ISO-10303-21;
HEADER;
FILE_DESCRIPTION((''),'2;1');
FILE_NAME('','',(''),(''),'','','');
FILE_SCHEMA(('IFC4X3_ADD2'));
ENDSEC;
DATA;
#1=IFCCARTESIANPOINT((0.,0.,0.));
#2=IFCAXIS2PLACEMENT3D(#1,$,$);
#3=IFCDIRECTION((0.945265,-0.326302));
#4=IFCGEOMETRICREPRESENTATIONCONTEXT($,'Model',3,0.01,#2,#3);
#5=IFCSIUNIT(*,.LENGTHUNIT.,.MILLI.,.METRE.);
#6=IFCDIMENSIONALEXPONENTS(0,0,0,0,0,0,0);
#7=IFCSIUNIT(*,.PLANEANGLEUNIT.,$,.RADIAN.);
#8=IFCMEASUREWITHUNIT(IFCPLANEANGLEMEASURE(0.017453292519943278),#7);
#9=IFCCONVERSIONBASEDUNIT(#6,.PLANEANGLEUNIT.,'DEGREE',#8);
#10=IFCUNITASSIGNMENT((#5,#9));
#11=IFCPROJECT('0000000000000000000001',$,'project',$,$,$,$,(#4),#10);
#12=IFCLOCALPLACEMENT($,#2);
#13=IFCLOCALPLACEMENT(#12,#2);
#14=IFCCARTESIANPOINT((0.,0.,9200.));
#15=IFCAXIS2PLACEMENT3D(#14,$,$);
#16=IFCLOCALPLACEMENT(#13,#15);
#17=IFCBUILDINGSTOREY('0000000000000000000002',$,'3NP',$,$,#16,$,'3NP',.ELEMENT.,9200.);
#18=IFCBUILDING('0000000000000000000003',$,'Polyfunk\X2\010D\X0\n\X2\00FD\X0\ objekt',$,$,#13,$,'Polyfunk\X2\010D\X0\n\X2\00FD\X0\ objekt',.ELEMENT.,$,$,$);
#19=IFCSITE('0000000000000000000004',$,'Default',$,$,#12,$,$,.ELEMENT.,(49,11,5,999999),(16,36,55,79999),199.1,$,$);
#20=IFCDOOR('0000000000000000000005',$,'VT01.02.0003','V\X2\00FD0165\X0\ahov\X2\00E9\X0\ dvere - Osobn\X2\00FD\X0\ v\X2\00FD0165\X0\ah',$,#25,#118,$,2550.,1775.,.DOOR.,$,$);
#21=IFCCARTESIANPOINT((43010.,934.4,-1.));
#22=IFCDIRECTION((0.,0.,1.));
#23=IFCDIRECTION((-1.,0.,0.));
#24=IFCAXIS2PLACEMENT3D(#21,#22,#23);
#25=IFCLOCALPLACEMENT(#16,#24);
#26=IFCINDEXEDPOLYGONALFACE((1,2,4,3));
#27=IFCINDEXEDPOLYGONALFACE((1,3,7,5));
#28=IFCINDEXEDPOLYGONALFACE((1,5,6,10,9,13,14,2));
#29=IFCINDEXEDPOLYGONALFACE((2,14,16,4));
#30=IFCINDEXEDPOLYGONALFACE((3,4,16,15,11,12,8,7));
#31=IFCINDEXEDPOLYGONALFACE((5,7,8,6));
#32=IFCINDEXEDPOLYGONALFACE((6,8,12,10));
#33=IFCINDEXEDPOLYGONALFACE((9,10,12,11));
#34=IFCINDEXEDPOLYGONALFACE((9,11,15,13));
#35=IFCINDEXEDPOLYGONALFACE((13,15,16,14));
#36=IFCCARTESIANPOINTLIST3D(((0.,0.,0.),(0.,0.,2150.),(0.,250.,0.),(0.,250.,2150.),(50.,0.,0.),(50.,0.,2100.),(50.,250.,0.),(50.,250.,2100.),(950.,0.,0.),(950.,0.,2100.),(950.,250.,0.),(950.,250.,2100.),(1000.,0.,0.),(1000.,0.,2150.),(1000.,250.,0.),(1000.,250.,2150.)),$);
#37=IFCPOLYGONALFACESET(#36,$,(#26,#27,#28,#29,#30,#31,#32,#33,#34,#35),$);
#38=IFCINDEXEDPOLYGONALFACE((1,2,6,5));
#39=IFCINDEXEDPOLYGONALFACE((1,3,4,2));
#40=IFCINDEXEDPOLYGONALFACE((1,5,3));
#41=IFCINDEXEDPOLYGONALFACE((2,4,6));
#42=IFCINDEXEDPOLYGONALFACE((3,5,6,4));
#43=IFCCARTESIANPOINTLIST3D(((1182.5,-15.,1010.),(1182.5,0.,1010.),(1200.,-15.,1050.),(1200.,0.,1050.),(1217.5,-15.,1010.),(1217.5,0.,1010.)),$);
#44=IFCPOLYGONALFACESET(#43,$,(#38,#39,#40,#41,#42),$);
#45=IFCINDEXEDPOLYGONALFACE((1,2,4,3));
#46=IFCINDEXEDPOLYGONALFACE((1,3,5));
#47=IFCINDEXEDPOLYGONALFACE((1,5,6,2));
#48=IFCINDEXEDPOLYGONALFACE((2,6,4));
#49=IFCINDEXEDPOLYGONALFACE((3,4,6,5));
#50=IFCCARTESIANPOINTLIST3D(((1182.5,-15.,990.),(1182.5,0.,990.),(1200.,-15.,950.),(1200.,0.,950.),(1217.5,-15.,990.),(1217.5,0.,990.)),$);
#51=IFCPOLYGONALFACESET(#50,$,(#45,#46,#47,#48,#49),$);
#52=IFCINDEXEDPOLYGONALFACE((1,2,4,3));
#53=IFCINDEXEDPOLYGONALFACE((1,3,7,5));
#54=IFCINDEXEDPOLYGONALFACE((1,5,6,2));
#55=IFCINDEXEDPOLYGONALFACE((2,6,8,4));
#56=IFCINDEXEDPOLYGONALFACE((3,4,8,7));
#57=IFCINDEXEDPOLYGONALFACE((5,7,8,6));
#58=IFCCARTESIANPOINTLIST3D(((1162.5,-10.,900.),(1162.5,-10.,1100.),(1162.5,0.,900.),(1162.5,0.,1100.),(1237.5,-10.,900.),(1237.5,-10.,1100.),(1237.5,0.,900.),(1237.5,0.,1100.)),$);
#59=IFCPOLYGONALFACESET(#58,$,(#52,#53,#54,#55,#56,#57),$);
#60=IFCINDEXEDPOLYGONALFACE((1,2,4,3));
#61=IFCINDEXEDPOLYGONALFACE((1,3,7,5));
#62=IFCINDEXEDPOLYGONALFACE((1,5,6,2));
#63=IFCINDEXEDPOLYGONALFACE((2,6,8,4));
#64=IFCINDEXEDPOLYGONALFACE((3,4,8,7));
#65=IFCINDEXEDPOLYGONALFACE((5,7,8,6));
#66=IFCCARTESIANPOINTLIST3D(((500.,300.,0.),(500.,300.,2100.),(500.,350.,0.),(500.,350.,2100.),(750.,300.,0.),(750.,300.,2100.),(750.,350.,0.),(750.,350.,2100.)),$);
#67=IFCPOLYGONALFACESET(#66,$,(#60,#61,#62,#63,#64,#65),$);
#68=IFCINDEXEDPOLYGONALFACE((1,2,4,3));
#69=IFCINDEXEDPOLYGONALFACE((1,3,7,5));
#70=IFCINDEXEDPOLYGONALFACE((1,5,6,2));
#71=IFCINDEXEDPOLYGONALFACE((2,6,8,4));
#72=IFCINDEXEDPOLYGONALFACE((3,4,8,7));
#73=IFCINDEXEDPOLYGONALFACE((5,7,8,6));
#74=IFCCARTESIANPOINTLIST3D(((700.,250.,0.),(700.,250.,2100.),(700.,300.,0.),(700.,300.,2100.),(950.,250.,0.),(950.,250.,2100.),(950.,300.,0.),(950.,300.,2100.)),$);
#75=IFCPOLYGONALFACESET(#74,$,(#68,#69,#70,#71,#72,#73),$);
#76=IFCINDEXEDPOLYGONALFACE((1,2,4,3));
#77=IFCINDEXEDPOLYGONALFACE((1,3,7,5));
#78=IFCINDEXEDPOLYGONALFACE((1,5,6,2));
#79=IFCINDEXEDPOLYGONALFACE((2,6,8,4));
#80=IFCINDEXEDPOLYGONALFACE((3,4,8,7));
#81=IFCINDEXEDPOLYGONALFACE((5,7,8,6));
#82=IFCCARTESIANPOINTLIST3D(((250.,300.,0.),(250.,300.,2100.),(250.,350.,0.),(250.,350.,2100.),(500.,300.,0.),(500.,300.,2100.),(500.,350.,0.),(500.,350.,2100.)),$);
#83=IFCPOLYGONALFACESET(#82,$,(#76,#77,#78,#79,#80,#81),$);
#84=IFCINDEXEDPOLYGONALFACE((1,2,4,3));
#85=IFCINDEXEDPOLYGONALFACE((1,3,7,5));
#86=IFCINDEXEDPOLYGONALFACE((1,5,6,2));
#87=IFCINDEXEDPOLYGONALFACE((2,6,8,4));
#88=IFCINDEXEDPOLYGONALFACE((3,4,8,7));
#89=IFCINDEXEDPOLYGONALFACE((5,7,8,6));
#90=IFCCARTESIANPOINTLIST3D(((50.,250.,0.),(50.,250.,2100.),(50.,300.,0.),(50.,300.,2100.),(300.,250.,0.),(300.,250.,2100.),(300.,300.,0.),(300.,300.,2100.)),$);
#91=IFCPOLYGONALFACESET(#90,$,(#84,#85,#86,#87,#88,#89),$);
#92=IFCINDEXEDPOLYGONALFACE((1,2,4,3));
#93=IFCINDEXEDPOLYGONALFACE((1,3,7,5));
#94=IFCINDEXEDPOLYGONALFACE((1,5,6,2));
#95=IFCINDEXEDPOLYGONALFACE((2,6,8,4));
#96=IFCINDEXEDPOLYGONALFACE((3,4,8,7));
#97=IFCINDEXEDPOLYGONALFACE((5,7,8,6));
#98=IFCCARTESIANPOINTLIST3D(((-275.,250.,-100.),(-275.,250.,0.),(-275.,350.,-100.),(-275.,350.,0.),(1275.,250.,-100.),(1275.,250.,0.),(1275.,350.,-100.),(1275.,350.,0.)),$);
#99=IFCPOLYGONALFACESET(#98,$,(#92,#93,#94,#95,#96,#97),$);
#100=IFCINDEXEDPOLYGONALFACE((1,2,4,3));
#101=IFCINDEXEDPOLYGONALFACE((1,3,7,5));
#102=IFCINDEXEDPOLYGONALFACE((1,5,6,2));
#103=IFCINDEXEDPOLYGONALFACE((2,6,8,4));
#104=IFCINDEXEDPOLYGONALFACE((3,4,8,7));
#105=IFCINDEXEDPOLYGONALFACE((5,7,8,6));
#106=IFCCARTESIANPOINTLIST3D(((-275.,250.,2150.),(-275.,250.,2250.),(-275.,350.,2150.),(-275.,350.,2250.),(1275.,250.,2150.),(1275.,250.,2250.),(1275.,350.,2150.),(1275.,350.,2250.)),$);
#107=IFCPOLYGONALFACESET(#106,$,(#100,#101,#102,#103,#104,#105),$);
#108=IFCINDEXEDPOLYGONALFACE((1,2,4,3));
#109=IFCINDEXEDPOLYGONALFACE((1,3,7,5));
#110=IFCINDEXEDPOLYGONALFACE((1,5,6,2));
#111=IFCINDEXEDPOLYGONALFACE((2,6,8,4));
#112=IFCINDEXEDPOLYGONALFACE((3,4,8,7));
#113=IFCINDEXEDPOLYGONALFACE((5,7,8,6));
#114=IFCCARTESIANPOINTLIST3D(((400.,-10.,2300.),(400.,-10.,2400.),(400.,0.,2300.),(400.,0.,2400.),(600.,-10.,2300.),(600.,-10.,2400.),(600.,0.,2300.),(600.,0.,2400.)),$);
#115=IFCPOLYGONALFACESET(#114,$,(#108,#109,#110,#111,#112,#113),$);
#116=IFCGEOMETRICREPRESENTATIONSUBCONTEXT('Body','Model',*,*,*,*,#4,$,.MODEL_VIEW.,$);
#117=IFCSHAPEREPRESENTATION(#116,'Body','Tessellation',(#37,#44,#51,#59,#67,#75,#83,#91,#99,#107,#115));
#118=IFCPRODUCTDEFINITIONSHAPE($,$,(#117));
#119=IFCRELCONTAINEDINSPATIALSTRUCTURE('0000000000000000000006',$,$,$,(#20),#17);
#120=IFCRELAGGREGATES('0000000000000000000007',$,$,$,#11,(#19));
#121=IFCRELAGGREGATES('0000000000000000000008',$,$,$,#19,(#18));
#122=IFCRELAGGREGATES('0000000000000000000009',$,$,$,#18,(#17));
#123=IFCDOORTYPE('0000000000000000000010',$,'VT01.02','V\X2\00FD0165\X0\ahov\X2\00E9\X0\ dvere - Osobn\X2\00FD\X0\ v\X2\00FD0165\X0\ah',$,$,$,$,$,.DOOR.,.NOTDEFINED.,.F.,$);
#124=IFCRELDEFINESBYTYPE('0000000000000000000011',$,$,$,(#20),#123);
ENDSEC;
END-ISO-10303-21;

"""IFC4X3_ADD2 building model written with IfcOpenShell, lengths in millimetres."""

from ifc_helpers import new_model, entity, si_unit, converted_unit, direction, frame, frame_2d, origin, origin_2d_with_axis, place, context, subcontext, project, spatial, polyline, rectangle, outline, extrude, source, transform, mapped, type_object, type_shapes, element, save


model = new_model("IFC4X3_ADD2")

# Units and contexts
model_context = context("Model", 3, precision=0.01, world=origin(), true_north=direction((0.945265, -0.326302)))
body_context = subcontext(model_context, "Body", "Model", "MODEL_VIEW")
ifc_project = project(units=[si_unit("LENGTHUNIT", "METRE", prefix="MILLI"), converted_unit("PLANEANGLEUNIT", "DEGREE", entity("IfcPlaneAngleMeasure", 0.017453292519943278), si_unit("PLANEANGLEUNIT", "RADIAN"), dimensions=[0, 0, 0, 0, 0, 0, 0])], contexts=[model_context])

# Site, building, storey
site_placement = place(None, origin())
site = spatial("IfcSite", under=ifc_project, at=site_placement, Name="Default", CompositionType="ELEMENT", RefLatitude=(49, 11, 5, 999999), RefLongitude=(16, 36, 55, 79999), RefElevation=199.1)
building_placement = place(site_placement, origin())
building = spatial("IfcBuilding", under=site, at=building_placement, Name="Polyfunkčný objekt", LongName="Polyfunkčný objekt", CompositionType="ELEMENT")
storey_placement = place(building_placement, frame((0.0, 0.0, 9200.0)))
storey = spatial("IfcBuildingStorey", under=building, at=storey_placement, Name="3NP", LongName="3NP", CompositionType="ELEMENT", Elevation=9200.0)

# Door
door_type_1 = type_object("IfcDoorType", Name="VT01.02", Description="Výťahové dvere - Osobný výťah", OperationType="NOTDEFINED", ParameterTakesPrecedence=False, PredefinedType="DOOR")
shared_shape_1 = source(origin(), body_context, "Body", "SweptSolid", [
    extrude(outline(polyline([(-1087.5, -500.0), (1062.5, -500.0), (1062.5, -450.0), (-1037.5, -450.0), (-1037.5, 450.0), (1062.5, 450.0), (1062.5, 500.0), (-1087.5, 500.0), (-1087.5, -500.0)])), frame((500.0, 0.0, 1062.5), z_axis=(0.0, 1.0, 0.0), x_axis=(0.0, 0.0, -1.0)), (0.0, 0.0, 1.0), 250.0),
    extrude(outline(polyline([(-24.4, -10.7), (19.2, -10.7), (5.2, 21.4), (-24.4, -10.7)])), frame((1200.0, -15.0, 1023.3), z_axis=(0.0, 1.0, 0.0), x_axis=(0.400819, 0.0, -0.916157)), (0.0, 0.0, 1.0), 15.0),
    extrude(outline(polyline([(-24.4, -10.7), (19.2, -10.7), (5.2, 21.4), (-24.4, -10.7)])), frame((1200.0, -15.0, 976.7), z_axis=(0.0, 1.0, 0.0), x_axis=(-0.400819, 0.0, 0.916157)), (0.0, 0.0, 1.0), 15.0),
    extrude(rectangle(XDim=10.0, YDim=75.0, at=frame_2d((0.0, 0.0), x_axis=(1.0, 0.0))), frame((1200.0, -5.0, 900.0), z_axis=(0.0, 0.0, 1.0), x_axis=(0.0, 1.0, 0.0)), (0.0, 0.0, 1.0), 200.0),
    extrude(rectangle(XDim=50.0, YDim=250.0, at=origin_2d_with_axis()), frame((625.0, 325.0, 0.0), z_axis=(0.0, 0.0, 1.0), x_axis=(0.0, -1.0, 0.0)), (0.0, 0.0, 1.0), 2100.0),
    extrude(rectangle(XDim=50.0, YDim=250.0, at=frame_2d((0.0, 0.0), x_axis=(1.0, 0.0))), frame((825.0, 275.0, 0.0), z_axis=(0.0, 0.0, 1.0), x_axis=(0.0, -1.0, 0.0)), (0.0, 0.0, 1.0), 2100.0),
    extrude(rectangle(XDim=250.0, YDim=50.0, at=frame_2d((0.0, 0.0), x_axis=(1.0, 0.0))), frame((375.0, 325.0, 0.0), z_axis=(0.0, 0.0, 1.0), x_axis=(-1.0, 0.0, 0.0)), (0.0, 0.0, 1.0), 2100.0),
    extrude(rectangle(XDim=250.0, YDim=50.0, at=frame_2d((0.0, 0.0), x_axis=(1.0, 0.0))), frame((175.0, 275.0, 0.0), z_axis=(0.0, 0.0, 1.0), x_axis=(-1.0, 0.0, 0.0)), (0.0, 0.0, 1.0), 2100.0),
    extrude(rectangle(XDim=1550.0, YDim=100.0, at=frame_2d((0.0, 0.0), x_axis=(1.0, 0.0))), frame((500.0, 300.0, -100.0), z_axis=(0.0, 0.0, 1.0), x_axis=(-1.0, 0.0, 0.0)), (0.0, 0.0, 1.0), 100.0),
    extrude(rectangle(XDim=1550.0, YDim=100.0, at=frame_2d((0.0, 0.0), x_axis=(1.0, 0.0))), frame((500.0, 300.0, 2150.0), z_axis=(0.0, 0.0, 1.0), x_axis=(-1.0, 0.0, 0.0)), (0.0, 0.0, 1.0), 100.0),
    extrude(rectangle(XDim=10.0, YDim=200.0, at=frame_2d((0.0, 0.0), x_axis=(1.0, 0.0))), frame((500.0, -5.0, 2300.0), z_axis=(0.0, 0.0, 1.0), x_axis=(0.0, 1.0, 0.0)), (0.0, 0.0, 1.0), 100.0),
])
type_shapes(door_type_1, [shared_shape_1])
door_1_placement = place(storey_placement, frame((43010.0, 934.4, -1.0), z_axis=(0.0, 0.0, 1.0), x_axis=(-1.0, 0.0, 0.0)))
element("IfcDoor", 1, at=door_1_placement, inside=storey, type_object=door_type_1, Name="VT01.02.0003", Description="Výťahové dvere - Osobný výťah", OverallHeight=2550.0, OverallWidth=1775.0, PredefinedType="DOOR", context=body_context, shape_type="MappedRepresentation", body=[
    mapped(shared_shape_1, transform((0.0, 0.0, 0.0), scale=1.0)),
])

save(model, "model.ifc")
